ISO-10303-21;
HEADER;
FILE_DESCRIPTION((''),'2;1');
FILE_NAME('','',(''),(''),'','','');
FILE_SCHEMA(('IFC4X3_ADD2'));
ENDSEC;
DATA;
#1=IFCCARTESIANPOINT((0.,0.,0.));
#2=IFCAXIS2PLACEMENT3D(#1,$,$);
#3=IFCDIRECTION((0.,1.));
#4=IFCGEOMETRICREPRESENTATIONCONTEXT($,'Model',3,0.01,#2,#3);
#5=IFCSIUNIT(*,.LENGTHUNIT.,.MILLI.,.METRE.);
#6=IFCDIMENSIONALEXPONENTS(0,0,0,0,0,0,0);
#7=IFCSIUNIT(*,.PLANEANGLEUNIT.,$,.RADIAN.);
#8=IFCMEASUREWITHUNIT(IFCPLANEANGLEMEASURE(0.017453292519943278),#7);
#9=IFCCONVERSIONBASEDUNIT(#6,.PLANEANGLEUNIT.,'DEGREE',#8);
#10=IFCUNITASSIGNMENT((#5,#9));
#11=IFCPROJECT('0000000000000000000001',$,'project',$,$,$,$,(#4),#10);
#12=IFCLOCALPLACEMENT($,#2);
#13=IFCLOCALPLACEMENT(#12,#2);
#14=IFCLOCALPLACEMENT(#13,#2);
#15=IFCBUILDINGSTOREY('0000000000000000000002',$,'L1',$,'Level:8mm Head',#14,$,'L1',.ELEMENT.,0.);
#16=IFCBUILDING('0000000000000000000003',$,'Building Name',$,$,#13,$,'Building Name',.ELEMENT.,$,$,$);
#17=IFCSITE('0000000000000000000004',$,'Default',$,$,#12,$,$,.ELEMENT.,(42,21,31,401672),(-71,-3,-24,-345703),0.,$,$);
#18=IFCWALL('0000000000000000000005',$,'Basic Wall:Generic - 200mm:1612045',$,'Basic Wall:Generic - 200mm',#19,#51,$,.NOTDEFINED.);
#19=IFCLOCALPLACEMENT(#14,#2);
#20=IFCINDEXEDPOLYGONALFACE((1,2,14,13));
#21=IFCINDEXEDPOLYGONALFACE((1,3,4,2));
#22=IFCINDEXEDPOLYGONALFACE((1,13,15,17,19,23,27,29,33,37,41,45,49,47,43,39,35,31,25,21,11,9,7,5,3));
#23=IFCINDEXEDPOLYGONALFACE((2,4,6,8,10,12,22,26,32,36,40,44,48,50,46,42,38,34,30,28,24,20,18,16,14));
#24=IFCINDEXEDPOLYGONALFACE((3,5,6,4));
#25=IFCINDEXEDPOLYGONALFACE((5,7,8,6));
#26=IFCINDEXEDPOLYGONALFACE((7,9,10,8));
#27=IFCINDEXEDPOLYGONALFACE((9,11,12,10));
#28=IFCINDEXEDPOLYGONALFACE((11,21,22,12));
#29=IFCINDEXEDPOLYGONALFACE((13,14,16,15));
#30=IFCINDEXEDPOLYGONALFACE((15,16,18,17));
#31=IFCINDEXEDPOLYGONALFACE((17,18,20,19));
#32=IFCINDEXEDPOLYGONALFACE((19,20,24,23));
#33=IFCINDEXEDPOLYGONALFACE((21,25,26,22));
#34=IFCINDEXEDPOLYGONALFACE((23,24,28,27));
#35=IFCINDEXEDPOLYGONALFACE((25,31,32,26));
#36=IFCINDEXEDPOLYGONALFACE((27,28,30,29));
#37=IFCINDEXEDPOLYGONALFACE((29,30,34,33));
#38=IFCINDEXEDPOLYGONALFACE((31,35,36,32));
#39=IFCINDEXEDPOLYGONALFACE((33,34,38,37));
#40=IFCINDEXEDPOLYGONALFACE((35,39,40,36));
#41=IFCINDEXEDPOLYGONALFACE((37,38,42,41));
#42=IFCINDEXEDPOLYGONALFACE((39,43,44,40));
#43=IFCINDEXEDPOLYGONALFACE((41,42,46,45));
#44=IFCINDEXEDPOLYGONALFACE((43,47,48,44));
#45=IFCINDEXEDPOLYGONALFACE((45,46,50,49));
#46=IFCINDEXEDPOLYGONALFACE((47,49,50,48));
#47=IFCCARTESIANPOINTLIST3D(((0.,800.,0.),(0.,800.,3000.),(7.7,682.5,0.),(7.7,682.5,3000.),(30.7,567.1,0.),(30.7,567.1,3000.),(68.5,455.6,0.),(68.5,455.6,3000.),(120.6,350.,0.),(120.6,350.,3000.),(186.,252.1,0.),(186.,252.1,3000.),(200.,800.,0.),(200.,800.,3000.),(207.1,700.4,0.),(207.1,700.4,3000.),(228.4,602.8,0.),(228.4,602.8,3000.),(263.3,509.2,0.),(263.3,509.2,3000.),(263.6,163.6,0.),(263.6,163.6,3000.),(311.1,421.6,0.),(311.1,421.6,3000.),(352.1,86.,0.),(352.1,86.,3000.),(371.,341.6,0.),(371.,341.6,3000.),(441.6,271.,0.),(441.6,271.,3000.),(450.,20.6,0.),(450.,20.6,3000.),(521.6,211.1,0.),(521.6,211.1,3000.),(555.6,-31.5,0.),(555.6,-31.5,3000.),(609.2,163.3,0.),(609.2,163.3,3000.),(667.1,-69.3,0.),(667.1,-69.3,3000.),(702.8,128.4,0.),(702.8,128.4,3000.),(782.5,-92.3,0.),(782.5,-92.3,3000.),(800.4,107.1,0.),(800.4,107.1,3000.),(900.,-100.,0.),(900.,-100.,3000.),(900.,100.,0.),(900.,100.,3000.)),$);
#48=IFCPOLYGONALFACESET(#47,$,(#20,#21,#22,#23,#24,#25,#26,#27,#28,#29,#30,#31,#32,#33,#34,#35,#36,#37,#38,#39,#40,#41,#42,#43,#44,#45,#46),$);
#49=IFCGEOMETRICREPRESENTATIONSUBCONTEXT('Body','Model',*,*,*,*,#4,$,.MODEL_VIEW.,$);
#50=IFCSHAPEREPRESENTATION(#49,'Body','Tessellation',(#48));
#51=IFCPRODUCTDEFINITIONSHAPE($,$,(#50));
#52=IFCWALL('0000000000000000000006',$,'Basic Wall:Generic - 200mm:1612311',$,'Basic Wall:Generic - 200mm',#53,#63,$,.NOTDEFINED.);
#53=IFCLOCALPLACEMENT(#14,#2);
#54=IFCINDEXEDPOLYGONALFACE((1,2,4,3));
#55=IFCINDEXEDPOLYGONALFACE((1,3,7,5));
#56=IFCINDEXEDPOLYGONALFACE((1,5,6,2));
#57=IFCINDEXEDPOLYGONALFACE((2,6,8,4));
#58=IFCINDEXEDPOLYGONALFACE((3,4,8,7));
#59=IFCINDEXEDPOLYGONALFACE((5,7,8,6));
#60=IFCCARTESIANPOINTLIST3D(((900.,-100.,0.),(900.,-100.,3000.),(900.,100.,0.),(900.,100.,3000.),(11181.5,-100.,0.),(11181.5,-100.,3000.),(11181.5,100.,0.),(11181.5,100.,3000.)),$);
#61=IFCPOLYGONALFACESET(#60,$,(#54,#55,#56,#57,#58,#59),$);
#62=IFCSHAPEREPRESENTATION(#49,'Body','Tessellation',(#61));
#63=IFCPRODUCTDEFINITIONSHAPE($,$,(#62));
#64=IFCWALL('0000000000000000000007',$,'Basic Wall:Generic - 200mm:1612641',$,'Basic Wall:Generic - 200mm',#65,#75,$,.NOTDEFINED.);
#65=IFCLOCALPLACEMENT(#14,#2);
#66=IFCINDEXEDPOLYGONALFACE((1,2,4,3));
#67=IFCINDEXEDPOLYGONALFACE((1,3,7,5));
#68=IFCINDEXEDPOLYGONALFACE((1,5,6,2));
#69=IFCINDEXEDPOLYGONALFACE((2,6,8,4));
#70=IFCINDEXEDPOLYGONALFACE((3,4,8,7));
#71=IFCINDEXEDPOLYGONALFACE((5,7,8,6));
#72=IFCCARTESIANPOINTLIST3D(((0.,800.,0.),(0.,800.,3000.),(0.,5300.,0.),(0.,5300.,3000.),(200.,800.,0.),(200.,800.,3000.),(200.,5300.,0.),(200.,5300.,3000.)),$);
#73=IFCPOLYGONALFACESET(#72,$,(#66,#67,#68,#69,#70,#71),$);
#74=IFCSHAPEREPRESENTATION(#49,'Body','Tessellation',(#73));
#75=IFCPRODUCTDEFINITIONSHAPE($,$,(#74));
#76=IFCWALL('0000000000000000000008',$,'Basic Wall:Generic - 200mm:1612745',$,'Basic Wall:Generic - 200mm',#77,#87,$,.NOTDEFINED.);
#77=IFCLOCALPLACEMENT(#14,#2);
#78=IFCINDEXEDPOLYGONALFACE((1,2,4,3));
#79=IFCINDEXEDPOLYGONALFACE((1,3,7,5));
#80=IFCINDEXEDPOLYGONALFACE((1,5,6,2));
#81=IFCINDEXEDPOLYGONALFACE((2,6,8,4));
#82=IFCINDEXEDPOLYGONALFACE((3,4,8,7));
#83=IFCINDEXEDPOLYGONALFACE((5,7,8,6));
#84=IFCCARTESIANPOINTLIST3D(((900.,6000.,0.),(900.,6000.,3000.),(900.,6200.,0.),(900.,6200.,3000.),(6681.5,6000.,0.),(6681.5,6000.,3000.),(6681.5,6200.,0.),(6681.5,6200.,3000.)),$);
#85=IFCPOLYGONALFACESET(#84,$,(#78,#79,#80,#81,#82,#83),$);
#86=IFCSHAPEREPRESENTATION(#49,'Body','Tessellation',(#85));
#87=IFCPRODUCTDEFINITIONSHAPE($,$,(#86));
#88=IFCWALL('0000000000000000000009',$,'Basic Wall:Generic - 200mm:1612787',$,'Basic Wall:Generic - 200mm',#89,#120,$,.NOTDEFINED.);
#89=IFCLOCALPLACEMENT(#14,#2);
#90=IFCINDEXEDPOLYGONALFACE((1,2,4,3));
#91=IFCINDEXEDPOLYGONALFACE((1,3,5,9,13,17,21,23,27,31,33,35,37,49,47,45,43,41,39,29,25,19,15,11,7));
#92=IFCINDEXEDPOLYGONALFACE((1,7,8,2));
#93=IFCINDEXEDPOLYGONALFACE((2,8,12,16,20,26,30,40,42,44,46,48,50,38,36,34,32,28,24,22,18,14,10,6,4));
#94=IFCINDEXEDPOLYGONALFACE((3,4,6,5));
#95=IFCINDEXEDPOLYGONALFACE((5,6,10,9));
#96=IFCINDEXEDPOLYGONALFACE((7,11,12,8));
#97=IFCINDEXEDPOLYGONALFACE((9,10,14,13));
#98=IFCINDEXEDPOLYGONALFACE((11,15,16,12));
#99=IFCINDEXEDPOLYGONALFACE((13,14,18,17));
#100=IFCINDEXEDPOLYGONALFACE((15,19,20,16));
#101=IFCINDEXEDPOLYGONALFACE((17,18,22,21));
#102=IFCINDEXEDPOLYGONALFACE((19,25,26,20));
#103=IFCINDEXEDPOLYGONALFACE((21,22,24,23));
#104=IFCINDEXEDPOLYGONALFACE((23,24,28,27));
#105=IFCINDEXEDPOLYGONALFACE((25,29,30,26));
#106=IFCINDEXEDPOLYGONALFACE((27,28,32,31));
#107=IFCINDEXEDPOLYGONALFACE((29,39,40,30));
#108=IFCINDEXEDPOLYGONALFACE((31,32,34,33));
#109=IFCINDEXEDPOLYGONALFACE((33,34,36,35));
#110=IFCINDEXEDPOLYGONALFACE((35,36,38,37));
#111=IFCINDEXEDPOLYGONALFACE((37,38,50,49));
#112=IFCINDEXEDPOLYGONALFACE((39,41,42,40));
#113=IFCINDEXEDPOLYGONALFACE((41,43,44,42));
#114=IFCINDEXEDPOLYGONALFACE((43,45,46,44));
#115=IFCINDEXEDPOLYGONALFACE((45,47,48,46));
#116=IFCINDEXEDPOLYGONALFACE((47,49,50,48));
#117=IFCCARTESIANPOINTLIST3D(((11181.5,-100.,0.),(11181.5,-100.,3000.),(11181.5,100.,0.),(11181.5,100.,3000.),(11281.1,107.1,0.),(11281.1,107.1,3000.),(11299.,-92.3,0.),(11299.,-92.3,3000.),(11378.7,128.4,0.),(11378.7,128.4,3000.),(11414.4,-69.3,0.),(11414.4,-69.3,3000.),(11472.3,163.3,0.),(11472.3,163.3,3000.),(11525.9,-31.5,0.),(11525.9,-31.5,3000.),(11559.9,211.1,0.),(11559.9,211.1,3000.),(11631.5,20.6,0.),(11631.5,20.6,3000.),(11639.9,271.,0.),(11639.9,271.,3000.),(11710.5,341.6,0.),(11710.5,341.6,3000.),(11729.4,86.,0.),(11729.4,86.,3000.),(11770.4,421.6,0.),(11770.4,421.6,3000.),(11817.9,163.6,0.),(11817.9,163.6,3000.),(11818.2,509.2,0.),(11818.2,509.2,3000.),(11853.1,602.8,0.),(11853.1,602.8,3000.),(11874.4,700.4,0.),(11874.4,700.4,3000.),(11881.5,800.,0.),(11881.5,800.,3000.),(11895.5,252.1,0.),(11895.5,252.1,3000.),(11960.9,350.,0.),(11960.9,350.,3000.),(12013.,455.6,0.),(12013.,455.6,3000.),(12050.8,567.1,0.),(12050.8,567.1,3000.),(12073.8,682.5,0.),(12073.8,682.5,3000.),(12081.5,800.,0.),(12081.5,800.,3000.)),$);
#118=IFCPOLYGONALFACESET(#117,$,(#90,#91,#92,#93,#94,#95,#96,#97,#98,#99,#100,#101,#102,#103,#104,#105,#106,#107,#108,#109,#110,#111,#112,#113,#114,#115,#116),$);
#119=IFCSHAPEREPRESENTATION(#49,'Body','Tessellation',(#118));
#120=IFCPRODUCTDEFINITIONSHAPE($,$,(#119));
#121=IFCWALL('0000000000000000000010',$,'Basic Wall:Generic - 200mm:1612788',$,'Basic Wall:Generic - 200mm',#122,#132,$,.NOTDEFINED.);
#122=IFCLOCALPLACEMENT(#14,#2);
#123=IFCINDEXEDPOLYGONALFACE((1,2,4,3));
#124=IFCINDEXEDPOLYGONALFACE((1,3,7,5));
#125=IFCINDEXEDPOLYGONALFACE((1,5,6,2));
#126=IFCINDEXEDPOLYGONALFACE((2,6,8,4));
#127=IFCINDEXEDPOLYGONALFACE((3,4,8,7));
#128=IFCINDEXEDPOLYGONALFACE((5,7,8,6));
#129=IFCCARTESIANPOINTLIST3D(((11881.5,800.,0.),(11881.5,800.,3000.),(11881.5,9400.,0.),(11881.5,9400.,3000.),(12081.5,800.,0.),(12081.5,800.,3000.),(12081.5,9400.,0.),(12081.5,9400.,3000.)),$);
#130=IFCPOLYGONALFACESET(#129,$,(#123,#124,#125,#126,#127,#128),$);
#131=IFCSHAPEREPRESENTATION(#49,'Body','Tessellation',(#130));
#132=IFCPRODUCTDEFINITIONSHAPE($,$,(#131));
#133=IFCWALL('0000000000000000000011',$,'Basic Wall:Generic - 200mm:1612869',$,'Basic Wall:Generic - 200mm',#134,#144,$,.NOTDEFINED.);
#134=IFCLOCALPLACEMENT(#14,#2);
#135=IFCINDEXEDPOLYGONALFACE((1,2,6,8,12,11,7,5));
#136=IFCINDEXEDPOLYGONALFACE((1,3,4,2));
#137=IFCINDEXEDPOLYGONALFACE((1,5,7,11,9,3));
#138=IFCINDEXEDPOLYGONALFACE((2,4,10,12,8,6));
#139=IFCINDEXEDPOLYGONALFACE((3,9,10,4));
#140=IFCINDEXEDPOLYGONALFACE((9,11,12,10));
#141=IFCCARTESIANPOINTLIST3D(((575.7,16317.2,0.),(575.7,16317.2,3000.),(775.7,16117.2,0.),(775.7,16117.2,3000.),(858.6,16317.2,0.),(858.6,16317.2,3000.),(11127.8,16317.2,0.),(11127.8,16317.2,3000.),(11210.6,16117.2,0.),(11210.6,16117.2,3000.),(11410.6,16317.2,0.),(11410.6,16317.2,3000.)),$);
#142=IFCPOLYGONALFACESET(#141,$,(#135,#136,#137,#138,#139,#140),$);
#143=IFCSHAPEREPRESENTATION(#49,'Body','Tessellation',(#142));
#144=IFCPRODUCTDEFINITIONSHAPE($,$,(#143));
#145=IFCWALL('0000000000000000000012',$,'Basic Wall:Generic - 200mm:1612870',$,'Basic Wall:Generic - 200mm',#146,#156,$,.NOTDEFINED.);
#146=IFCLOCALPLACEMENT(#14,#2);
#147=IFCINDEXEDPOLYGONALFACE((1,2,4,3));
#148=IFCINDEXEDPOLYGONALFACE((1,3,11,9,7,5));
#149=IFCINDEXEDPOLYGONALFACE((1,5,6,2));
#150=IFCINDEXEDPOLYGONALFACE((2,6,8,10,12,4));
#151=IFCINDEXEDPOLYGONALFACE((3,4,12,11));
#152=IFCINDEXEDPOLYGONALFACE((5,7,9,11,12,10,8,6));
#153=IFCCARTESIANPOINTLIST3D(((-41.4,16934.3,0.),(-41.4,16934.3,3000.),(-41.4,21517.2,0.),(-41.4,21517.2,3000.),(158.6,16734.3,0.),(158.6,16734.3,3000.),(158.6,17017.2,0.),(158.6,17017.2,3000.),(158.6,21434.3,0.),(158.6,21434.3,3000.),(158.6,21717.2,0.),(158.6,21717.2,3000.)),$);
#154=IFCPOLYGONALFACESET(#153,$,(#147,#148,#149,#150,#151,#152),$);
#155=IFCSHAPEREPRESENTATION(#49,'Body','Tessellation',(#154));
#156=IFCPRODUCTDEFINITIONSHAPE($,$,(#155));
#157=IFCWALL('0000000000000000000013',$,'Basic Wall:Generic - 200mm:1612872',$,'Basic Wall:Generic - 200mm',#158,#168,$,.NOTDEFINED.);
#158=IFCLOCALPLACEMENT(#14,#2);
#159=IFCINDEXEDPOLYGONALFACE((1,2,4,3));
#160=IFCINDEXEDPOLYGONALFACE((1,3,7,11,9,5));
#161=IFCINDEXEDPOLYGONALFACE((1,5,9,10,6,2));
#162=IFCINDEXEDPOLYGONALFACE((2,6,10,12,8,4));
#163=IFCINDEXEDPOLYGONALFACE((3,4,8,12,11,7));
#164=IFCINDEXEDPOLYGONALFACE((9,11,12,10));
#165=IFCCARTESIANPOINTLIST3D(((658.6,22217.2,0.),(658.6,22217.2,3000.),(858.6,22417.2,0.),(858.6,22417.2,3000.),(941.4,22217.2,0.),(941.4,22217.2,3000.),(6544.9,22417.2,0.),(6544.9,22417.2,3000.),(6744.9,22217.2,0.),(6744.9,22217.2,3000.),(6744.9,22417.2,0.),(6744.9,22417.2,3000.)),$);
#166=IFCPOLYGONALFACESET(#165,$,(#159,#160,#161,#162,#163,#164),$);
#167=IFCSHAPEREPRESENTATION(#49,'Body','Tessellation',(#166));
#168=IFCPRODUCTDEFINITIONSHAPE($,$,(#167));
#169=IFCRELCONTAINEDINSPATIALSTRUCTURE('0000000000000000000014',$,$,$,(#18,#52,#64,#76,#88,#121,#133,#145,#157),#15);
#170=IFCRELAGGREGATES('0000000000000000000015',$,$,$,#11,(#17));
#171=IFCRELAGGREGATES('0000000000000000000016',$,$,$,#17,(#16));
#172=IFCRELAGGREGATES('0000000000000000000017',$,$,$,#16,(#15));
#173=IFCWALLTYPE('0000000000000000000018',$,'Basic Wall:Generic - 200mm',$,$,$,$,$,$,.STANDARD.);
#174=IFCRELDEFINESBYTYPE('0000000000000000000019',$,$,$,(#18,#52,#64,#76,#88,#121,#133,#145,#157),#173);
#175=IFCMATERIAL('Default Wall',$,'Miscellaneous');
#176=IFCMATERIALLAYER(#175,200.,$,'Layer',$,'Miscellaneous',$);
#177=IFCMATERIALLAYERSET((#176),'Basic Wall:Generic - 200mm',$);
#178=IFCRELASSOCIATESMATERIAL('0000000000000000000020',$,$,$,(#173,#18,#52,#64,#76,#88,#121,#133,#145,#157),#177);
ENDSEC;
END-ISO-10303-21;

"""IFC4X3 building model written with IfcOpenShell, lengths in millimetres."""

from ifc_helpers import new_model, entity, si_unit, converted_unit, direction, frame, frame_2d, origin, place, context, subcontext, project, spatial, polyline, circle_curve, parameter, trimmed, segment, composite_curve, rectangle, outline, extrude, material, layer, layer_set, type_object, element, save


model = new_model("IFC4X3")

# Units and contexts
model_context = context("Model", 3, precision=0.01, world=origin(), true_north=direction((0.0, 1.0)))
body_context = subcontext(model_context, "Body", "Model", "MODEL_VIEW")
ifc_project = project(units=[si_unit("LENGTHUNIT", "METRE", prefix="MILLI"), converted_unit("PLANEANGLEUNIT", "DEGREE", entity("IfcPlaneAngleMeasure", 0.017453292519943278), si_unit("PLANEANGLEUNIT", "RADIAN"), dimensions=[0, 0, 0, 0, 0, 0, 0])], contexts=[model_context])

# Site, building, storey
site_placement = place(None, origin())
site = spatial("IfcSite", under=ifc_project, at=site_placement, Name="Default", CompositionType="ELEMENT", RefLatitude=(42, 21, 31, 401672), RefLongitude=(-71, -3, -24, -345703), RefElevation=0.0)
building_placement = place(site_placement, origin())
building = spatial("IfcBuilding", under=site, at=building_placement, Name="Building Name", LongName="Building Name", CompositionType="ELEMENT")
storey_placement = place(building_placement, origin())
storey = spatial("IfcBuildingStorey", under=building, at=storey_placement, Name="L1", ObjectType="Level:8mm Head", LongName="L1", CompositionType="ELEMENT", Elevation=0.0)

# Walls
ifc_material = material(Name="Default Wall", Category="Miscellaneous")
ifc_layer = layer(ifc_material, 200.0, Name="Layer", Category="Miscellaneous")
ifc_layer_set = layer_set([ifc_layer], Name="Basic Wall:Generic - 200mm")
wall_type = type_object("IfcWallType", Name="Basic Wall:Generic - 200mm", PredefinedType="STANDARD", material=ifc_layer_set)
wall_1_placement = place(storey_placement, frame((100.0, 800.0, 0.0)))
element("IfcWall", 1, at=wall_1_placement, inside=storey, type_object=wall_type, material=ifc_layer_set, Name="Basic Wall:Generic - 200mm:1612045", ObjectType="Basic Wall:Generic - 200mm", PredefinedType="NOTDEFINED", context=body_context, shape_type="SweptSolid", body=[
    extrude(outline(composite_curve([segment(trimmed(circle_curve(frame_2d((800.0, 0.0), x_axis=(1.0, 0.0)), 700.0), [parameter(180.0)], [parameter(270.0)], True, "PARAMETER"), False, "CONTINUOUS"), segment(polyline([(100.0, 0.0), (-100.0, 0.0)]), True, "CONTINUOUS"), segment(trimmed(circle_curve(frame_2d((800.0, 0.0), x_axis=(1.0, 0.0)), 900.0), [parameter(180.0)], [parameter(270.0)], True, "PARAMETER"), True, "CONTINUOUS"), segment(polyline([(800.0, -900.0), (800.0, -700.0)]), True, "CONTINUOUS")], self_intersect=False)), origin(), (0.0, 0.0, 1.0), 3000.0),
])
wall_2_placement = place(storey_placement, frame((11181.5, 0.0, 0.0), z_axis=(0.0, 0.0, 1.0), x_axis=(-1.0, 0.0, 0.0)))
element("IfcWall", 2, at=wall_2_placement, inside=storey, type_object=wall_type, material=ifc_layer_set, Name="Basic Wall:Generic - 200mm:1612311", ObjectType="Basic Wall:Generic - 200mm", PredefinedType="NOTDEFINED", context=body_context, shape_type="SweptSolid", body=[
    extrude(rectangle(XDim=10281.5, YDim=200.0, at=frame_2d((5140.7, 0.0), x_axis=(-1.0, 0.0))), origin(), (0.0, 0.0, 1.0), 3000.0),
])
wall_3_placement = place(storey_placement, frame((100.0, 800.0, 0.0), z_axis=(0.0, 0.0, 1.0), x_axis=(0.0, 1.0, 0.0)))
element("IfcWall", 3, at=wall_3_placement, inside=storey, type_object=wall_type, material=ifc_layer_set, Name="Basic Wall:Generic - 200mm:1612641", ObjectType="Basic Wall:Generic - 200mm", PredefinedType="NOTDEFINED", context=body_context, shape_type="SweptSolid", body=[
    extrude(rectangle(XDim=4500.0, YDim=200.0, at=frame_2d((2250.0, 0.0), x_axis=(-1.0, 0.0))), origin(), (0.0, 0.0, 1.0), 3000.0),
])
wall_4_placement = place(storey_placement, frame((6681.5, 6100.0, 0.0), z_axis=(0.0, 0.0, 1.0), x_axis=(-1.0, 0.0, 0.0)))
element("IfcWall", 4, at=wall_4_placement, inside=storey, type_object=wall_type, material=ifc_layer_set, Name="Basic Wall:Generic - 200mm:1612745", ObjectType="Basic Wall:Generic - 200mm", PredefinedType="NOTDEFINED", context=body_context, shape_type="SweptSolid", body=[
    extrude(rectangle(XDim=5781.5, YDim=200.0, at=frame_2d((2890.7, 0.0), x_axis=(-1.0, 0.0))), origin(), (0.0, 0.0, 1.0), 3000.0),
])
wall_5_placement = place(storey_placement, frame((11981.5, 800.0, 0.0), z_axis=(0.0, 0.0, 1.0), x_axis=(-1.0, 0.0, 0.0)))
element("IfcWall", 5, at=wall_5_placement, inside=storey, type_object=wall_type, material=ifc_layer_set, Name="Basic Wall:Generic - 200mm:1612787", ObjectType="Basic Wall:Generic - 200mm", PredefinedType="NOTDEFINED", context=body_context, shape_type="SweptSolid", body=[
    extrude(outline(composite_curve([segment(trimmed(circle_curve(frame_2d((800.0, 0.0), x_axis=(1.0, 0.0)), 900.0), [parameter(90.0)], [parameter(180.0)], True, "PARAMETER"), True, "CONTINUOUS"), segment(polyline([(-100.0, 0.0), (100.0, 0.0)]), True, "CONTINUOUS"), segment(trimmed(circle_curve(frame_2d((800.0, 0.0), x_axis=(1.0, 0.0)), 700.0), [parameter(90.0)], [parameter(180.0)], True, "PARAMETER"), False, "CONTINUOUS"), segment(polyline([(800.0, 700.0), (800.0, 900.0)]), True, "CONTINUOUS")], self_intersect=False)), origin(), (0.0, 0.0, 1.0), 3000.0),
])
wall_6_placement = place(storey_placement, frame((11981.5, 800.0, 0.0), z_axis=(0.0, 0.0, 1.0), x_axis=(0.0, 1.0, 0.0)))
element("IfcWall", 6, at=wall_6_placement, inside=storey, type_object=wall_type, material=ifc_layer_set, Name="Basic Wall:Generic - 200mm:1612788", ObjectType="Basic Wall:Generic - 200mm", PredefinedType="NOTDEFINED", context=body_context, shape_type="SweptSolid", body=[
    extrude(rectangle(XDim=8600.0, YDim=200.0, at=frame_2d((4300.0, 0.0), x_axis=(-1.0, 0.0))), origin(), (0.0, 0.0, 1.0), 3000.0),
])
wall_7_placement = place(storey_placement, frame((11410.6, 16217.2, 0.0), z_axis=(0.0, 0.0, 1.0), x_axis=(-1.0, 0.0, 0.0)))
element("IfcWall", 7, at=wall_7_placement, inside=storey, type_object=wall_type, material=ifc_layer_set, Name="Basic Wall:Generic - 200mm:1612869", ObjectType="Basic Wall:Generic - 200mm", PredefinedType="NOTDEFINED", context=body_context, shape_type="SweptSolid", body=[
    extrude(outline(polyline([(10834.9, -100.0), (10634.9, 100.0), (200.0, 100.0), (0.0, -100.0), (282.8, -100.0), (10552.0, -100.0), (10834.9, -100.0)])), origin(), (0.0, 0.0, 1.0), 3000.0),
])
wall_8_placement = place(storey_placement, frame((58.6, 16734.3, 0.0), z_axis=(0.0, 0.0, 1.0), x_axis=(0.0, 1.0, 0.0)))
element("IfcWall", 8, at=wall_8_placement, inside=storey, type_object=wall_type, material=ifc_layer_set, Name="Basic Wall:Generic - 200mm:1612870", ObjectType="Basic Wall:Generic - 200mm", PredefinedType="NOTDEFINED", context=body_context, shape_type="SweptSolid", body=[
    extrude(outline(polyline([(4982.8, -100.0), (4782.8, 100.0), (200.0, 100.0), (0.0, -100.0), (282.8, -100.0), (4700.0, -100.0), (4982.8, -100.0)])), origin(), (0.0, 0.0, 1.0), 3000.0),
])
wall_9_placement = place(storey_placement, frame((6744.9, 22317.2, 0.0), z_axis=(0.0, 0.0, 1.0), x_axis=(-1.0, 0.0, 0.0)))
element("IfcWall", 9, at=wall_9_placement, inside=storey, type_object=wall_type, material=ifc_layer_set, Name="Basic Wall:Generic - 200mm:1612872", ObjectType="Basic Wall:Generic - 200mm", PredefinedType="NOTDEFINED", context=body_context, shape_type="SweptSolid", body=[
    extrude(outline(polyline([(5886.3, -100.0), (6086.3, 100.0), (5803.5, 100.0), (0.0, 100.0), (0.0, -100.0), (200.0, -100.0), (5886.3, -100.0)])), origin(), (0.0, 0.0, 1.0), 3000.0),
])

save(model, "model.ifc")
